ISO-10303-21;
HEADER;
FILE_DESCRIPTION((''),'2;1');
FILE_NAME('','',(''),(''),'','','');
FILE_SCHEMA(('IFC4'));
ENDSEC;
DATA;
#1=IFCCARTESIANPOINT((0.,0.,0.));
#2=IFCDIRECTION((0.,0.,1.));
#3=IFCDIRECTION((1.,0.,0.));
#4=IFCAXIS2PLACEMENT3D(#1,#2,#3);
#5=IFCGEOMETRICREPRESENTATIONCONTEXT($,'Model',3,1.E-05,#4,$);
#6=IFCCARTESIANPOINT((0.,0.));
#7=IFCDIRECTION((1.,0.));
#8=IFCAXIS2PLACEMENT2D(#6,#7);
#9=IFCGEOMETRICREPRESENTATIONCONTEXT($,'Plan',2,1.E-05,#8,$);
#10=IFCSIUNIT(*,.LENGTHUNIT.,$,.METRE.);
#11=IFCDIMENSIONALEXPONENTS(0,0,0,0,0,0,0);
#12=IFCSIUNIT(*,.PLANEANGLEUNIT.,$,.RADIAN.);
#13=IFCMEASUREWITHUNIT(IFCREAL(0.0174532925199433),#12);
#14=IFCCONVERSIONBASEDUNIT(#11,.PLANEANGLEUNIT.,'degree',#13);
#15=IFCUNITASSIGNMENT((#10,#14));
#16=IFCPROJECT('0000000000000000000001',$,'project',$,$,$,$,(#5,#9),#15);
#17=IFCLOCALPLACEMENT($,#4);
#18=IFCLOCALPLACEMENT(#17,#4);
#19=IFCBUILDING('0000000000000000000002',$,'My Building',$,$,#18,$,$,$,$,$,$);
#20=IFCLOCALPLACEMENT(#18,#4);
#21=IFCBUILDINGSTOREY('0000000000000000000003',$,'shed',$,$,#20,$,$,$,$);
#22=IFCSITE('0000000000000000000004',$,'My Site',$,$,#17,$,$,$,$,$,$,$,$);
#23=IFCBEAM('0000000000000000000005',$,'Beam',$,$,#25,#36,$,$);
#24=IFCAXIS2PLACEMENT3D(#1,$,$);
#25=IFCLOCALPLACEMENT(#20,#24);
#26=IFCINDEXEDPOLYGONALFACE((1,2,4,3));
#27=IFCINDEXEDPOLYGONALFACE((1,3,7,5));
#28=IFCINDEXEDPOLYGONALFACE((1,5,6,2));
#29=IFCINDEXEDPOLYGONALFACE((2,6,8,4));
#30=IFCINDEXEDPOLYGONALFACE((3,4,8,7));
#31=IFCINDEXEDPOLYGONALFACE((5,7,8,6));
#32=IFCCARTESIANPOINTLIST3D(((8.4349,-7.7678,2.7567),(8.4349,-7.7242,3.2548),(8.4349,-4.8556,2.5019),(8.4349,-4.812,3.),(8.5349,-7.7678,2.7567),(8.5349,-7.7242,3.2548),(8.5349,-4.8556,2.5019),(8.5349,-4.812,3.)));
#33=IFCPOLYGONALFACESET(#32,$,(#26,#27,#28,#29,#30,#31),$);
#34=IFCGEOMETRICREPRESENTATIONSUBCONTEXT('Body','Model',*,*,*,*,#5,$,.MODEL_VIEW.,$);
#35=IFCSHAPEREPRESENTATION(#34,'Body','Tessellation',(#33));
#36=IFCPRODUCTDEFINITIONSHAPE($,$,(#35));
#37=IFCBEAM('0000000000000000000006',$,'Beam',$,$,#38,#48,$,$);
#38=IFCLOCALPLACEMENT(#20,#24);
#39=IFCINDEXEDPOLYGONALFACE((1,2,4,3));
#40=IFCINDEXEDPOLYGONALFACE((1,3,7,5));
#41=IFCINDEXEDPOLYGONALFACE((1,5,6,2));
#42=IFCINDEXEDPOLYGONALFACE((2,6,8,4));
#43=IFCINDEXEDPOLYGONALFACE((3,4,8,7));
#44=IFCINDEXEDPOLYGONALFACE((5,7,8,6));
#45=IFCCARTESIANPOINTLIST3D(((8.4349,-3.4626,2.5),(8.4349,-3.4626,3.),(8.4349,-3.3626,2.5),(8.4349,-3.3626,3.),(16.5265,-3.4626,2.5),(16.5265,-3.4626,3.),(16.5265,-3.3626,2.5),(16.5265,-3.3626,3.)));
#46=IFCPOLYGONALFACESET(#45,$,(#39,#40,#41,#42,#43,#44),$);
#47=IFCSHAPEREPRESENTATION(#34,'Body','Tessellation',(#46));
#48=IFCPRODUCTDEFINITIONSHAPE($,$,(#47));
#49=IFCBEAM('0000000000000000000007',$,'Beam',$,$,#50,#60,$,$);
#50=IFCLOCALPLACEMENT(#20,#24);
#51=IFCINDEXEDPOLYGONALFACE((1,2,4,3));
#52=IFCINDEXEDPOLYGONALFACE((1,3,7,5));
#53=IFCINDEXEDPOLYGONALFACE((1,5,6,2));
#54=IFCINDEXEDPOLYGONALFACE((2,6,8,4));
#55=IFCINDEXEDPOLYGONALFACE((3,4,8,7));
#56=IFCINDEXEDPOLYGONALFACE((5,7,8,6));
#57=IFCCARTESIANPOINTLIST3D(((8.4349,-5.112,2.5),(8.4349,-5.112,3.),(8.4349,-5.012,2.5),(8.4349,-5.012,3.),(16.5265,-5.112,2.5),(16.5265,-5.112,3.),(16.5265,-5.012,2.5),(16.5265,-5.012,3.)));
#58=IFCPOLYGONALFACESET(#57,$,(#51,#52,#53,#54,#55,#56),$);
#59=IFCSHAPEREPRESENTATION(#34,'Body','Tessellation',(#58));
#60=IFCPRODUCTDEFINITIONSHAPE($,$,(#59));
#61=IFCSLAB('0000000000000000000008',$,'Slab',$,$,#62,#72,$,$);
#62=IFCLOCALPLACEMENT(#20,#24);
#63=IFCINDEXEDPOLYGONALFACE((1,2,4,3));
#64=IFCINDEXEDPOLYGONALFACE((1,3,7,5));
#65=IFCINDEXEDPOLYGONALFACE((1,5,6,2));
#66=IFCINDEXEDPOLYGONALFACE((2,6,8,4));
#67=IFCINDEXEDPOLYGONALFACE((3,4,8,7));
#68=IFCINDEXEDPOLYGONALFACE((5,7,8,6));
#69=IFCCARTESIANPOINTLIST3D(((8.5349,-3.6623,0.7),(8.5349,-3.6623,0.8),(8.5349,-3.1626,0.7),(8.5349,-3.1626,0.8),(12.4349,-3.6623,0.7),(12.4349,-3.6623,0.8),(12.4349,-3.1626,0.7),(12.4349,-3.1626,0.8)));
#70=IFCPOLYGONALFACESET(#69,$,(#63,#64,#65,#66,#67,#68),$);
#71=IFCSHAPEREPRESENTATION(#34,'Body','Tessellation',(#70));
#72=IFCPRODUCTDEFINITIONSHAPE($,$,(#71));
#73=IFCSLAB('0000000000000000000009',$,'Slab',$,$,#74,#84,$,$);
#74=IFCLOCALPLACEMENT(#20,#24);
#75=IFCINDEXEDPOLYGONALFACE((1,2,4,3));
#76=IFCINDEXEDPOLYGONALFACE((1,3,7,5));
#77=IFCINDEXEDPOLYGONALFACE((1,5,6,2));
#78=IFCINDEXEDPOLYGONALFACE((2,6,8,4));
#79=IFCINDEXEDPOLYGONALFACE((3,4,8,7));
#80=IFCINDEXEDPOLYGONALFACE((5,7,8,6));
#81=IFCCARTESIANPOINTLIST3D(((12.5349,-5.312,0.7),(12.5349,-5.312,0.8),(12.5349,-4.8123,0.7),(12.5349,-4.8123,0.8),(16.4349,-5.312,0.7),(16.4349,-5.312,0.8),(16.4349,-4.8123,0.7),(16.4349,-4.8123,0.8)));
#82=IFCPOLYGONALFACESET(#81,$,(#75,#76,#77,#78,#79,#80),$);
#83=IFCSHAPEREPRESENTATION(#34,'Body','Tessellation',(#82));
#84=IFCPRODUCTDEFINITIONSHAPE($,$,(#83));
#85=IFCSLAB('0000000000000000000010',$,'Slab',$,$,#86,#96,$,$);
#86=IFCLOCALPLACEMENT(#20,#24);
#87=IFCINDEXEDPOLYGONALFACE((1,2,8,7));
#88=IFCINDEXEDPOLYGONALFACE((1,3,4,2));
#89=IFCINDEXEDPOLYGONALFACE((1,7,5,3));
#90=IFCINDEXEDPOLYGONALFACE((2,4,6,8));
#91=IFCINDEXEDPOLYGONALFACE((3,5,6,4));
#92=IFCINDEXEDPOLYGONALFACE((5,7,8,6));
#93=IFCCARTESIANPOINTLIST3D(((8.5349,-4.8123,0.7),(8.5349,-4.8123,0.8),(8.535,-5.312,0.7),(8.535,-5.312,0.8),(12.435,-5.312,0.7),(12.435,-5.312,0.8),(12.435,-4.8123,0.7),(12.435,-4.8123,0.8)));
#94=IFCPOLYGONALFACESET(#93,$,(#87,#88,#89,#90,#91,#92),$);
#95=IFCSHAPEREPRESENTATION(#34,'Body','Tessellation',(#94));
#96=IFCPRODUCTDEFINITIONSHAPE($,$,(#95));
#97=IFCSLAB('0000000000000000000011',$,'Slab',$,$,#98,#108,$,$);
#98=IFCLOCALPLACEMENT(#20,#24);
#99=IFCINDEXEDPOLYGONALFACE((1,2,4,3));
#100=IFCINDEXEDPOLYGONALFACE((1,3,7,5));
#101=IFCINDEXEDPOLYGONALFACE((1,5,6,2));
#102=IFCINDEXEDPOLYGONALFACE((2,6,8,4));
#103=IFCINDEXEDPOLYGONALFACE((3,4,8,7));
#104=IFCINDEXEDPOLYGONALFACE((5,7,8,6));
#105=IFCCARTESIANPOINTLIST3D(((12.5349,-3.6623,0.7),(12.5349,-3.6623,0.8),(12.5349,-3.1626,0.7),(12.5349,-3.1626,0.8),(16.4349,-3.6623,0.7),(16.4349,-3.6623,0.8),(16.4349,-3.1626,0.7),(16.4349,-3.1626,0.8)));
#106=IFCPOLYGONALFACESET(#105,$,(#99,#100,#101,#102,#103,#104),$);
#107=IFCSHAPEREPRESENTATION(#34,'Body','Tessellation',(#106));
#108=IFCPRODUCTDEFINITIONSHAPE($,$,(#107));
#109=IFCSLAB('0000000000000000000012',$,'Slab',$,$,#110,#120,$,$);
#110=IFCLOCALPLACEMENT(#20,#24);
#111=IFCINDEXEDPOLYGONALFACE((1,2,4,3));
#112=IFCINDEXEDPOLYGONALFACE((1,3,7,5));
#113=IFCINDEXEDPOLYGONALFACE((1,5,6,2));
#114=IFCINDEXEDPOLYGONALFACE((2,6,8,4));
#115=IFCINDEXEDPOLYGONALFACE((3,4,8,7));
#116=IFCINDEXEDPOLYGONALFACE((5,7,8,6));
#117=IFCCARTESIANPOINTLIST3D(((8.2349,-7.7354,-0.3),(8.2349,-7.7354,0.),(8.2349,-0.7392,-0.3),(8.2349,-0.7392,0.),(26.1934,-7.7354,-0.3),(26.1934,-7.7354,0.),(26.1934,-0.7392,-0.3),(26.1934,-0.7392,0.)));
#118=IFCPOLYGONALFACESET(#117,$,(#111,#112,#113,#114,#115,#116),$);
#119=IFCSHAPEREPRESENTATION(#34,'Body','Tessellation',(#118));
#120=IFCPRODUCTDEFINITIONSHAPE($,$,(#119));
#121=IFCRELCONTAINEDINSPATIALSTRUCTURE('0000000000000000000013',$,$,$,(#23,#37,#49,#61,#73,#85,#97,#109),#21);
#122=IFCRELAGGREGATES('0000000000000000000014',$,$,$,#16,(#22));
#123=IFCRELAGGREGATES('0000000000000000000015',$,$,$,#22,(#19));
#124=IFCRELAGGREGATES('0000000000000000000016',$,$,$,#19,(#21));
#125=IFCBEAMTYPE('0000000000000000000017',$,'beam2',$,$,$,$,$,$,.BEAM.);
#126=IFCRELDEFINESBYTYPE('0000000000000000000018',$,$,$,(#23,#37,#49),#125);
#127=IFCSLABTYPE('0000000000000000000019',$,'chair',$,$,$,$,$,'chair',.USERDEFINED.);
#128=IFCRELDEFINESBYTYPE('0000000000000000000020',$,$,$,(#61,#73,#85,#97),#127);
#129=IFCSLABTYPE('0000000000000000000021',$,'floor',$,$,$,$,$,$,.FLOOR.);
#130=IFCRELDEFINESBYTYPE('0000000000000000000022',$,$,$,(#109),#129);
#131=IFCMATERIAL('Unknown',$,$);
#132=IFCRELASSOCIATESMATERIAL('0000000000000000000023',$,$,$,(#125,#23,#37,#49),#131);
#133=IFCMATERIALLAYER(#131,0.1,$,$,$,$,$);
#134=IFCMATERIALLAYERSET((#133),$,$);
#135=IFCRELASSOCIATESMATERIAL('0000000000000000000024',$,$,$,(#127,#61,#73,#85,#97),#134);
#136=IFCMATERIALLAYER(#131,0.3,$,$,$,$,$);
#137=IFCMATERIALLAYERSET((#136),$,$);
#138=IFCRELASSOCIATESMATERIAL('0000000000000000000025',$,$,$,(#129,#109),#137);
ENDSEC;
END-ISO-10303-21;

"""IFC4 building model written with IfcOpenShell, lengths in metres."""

from ifc_helpers import new_model, entity, si_unit, converted_unit, frame, origin_with_axes, origin_2d_with_axis, place, context, subcontext, project, spatial, indexed_curve, rectangle, outline, extrude, material, layer, layer_set, layer_usage, material_profile, profile_set, profile_usage, type_object, element, save


model = new_model("IFC4")

# Units and contexts
model_context = context("Model", 3, precision=1e-05, world=origin_with_axes())
plan_context = context("Plan", 2, precision=1e-05, world=origin_2d_with_axis())
body_context = subcontext(model_context, "Body", "Model", "MODEL_VIEW")
ifc_project = project(units=[si_unit("LENGTHUNIT", "METRE"), converted_unit("PLANEANGLEUNIT", "degree", entity("IfcReal", 0.0174532925199433), si_unit("PLANEANGLEUNIT", "RADIAN"), dimensions=[0, 0, 0, 0, 0, 0, 0])], contexts=[model_context, plan_context])

# Site, building, storey
site_placement = place(None, origin_with_axes())
site = spatial("IfcSite", under=ifc_project, at=site_placement, Name="My Site")
building_placement = place(site_placement, origin_with_axes())
building = spatial("IfcBuilding", under=site, at=building_placement, Name="My Building")
storey_placement = place(building_placement, origin_with_axes())
storey = spatial("IfcBuildingStorey", under=building, at=storey_placement, Name="shed")

# Shared definitions
ifc_material = material(Name="Unknown")

# Beams
ifc_material_profile_1 = material_profile(ifc_material, rectangle(XDim=0.1, YDim=0.5))
ifc_profile_set_1 = profile_set([ifc_material_profile_1])
beam_type = type_object("IfcBeamType", Name="beam2", PredefinedType="BEAM", material=ifc_profile_set_1)
ifc_profile_usage_1 = profile_usage(ifc_profile_set_1, cardinal=8)
beam_1_placement = place(storey_placement, frame((8.4849, -4.812, 3.0), z_axis=(0.0, -0.996195, 0.087156), x_axis=(1.0, 0.0, 0.0)))
element("IfcBeam", 1, at=beam_1_placement, inside=storey, type_object=beam_type, material=ifc_profile_usage_1, Name="Beam", context=body_context, shape_type="SweptSolid", body=[
    extrude(rectangle(XDim=0.1, YDim=0.5), frame((0.0, -0.25, 0.0), z_axis=(0.0, 0.0, 1.0), x_axis=(1.0, 0.0, 0.0)), (0.0, 0.0, 1.0), 2.9234),
])
ifc_profile_usage_2 = profile_usage(ifc_profile_set_1, cardinal=8)
beam_2_placement = place(storey_placement, frame((8.4349, -3.4126, 3.0), z_axis=(1.0, -0.000001, 0.000001), x_axis=(0.000001, 1.0, 0.0)))
element("IfcBeam", 2, at=beam_2_placement, inside=storey, type_object=beam_type, material=ifc_profile_usage_2, Name="Beam", context=body_context, shape_type="SweptSolid", body=[
    extrude(rectangle(XDim=0.1, YDim=0.5), frame((0.0, -0.25, 0.0), z_axis=(0.0, 0.0, 1.0), x_axis=(1.0, 0.0, 0.0)), (0.0, 0.0, 1.0), 8.0916),
])
ifc_profile_usage_3 = profile_usage(ifc_profile_set_1, cardinal=8)
beam_3_placement = place(storey_placement, frame((8.4349, -5.062, 3.0), z_axis=(1.0, -0.000001, 0.000001), x_axis=(0.000001, 1.0, 0.0)))
element("IfcBeam", 3, at=beam_3_placement, inside=storey, type_object=beam_type, material=ifc_profile_usage_3, Name="Beam", context=body_context, shape_type="SweptSolid", body=[
    extrude(rectangle(XDim=0.1, YDim=0.5), frame((0.0, -0.25, 0.0), z_axis=(0.0, 0.0, 1.0), x_axis=(1.0, 0.0, 0.0)), (0.0, 0.0, 1.0), 8.0916),
])

# Slabs
ifc_layer_1 = layer(ifc_material, 0.1)
ifc_layer_set_1 = layer_set([ifc_layer_1])
ifc_layer_usage_1 = layer_usage(ifc_layer_set_1, "AXIS3", "POSITIVE", -0.1)
slab_type_1 = type_object("IfcSlabType", Name="chair", ElementType="chair", PredefinedType="USERDEFINED", material=ifc_layer_set_1)
slab_1_placement = place(storey_placement, frame((8.5349, -3.6623, 0.8), z_axis=(0.0, 0.0, 1.0), x_axis=(1.0, 0.0, 0.0)))
element("IfcSlab", 4, at=slab_1_placement, inside=storey, type_object=slab_type_1, material=ifc_layer_usage_1, Name="Slab", context=body_context, shape_type="SweptSolid", body=[
    extrude(outline(indexed_curve([(0.0, 0.0), (3.9, 0.0), (3.9, 0.4997), (0.0, 0.4997), (0.0, 0.0)])), frame((0.0, 0.0, -0.1), z_axis=(0.0, 0.0, 1.0), x_axis=(1.0, 0.0, 0.0)), (0.0, 0.0, 1.0), 0.1),
])
ifc_layer_usage_2 = layer_usage(ifc_layer_set_1, "AXIS3", "POSITIVE", -0.1)
slab_2_placement = place(storey_placement, frame((12.5349, -5.312, 0.8), z_axis=(0.0, 0.0, 1.0), x_axis=(1.0, 0.0, 0.0)))
element("IfcSlab", 5, at=slab_2_placement, inside=storey, type_object=slab_type_1, material=ifc_layer_usage_2, Name="Slab", context=body_context, shape_type="SweptSolid", body=[
    extrude(outline(indexed_curve([(0.0, 0.0), (3.9, 0.0), (3.9, 0.4997), (0.0, 0.4997), (0.0, 0.0)])), frame((0.0, 0.0, -0.1), z_axis=(0.0, 0.0, 1.0), x_axis=(1.0, 0.0, 0.0)), (0.0, 0.0, 1.0), 0.1),
])
ifc_layer_usage_3 = layer_usage(ifc_layer_set_1, "AXIS3", "POSITIVE", -0.1)
slab_3_placement = place(storey_placement, frame((8.535, -5.312, 0.8), z_axis=(0.0, 0.0, 1.0), x_axis=(1.0, 0.0, 0.0)))
element("IfcSlab", 6, at=slab_3_placement, inside=storey, type_object=slab_type_1, material=ifc_layer_usage_3, Name="Slab", context=body_context, shape_type="SweptSolid", body=[
    extrude(outline(indexed_curve([(0.0, 0.0), (3.9, 0.0), (3.9, 0.4997), (0.0, 0.4997), (0.0, 0.0)])), frame((0.0, 0.0, -0.1), z_axis=(0.0, 0.0, 1.0), x_axis=(1.0, 0.0, 0.0)), (0.0, 0.0, 1.0), 0.1),
])
ifc_layer_usage_4 = layer_usage(ifc_layer_set_1, "AXIS3", "POSITIVE", -0.1)
slab_4_placement = place(storey_placement, frame((12.5349, -3.6623, 0.8), z_axis=(0.0, 0.0, 1.0), x_axis=(1.0, 0.0, 0.0)))
element("IfcSlab", 7, at=slab_4_placement, inside=storey, type_object=slab_type_1, material=ifc_layer_usage_4, Name="Slab", context=body_context, shape_type="SweptSolid", body=[
    extrude(outline(indexed_curve([(0.0, 0.0), (3.9, 0.0), (3.9, 0.4997), (0.0, 0.4997), (0.0, 0.0)])), frame((0.0, 0.0, -0.1), z_axis=(0.0, 0.0, 1.0), x_axis=(1.0, 0.0, 0.0)), (0.0, 0.0, 1.0), 0.1),
])
ifc_layer_2 = layer(ifc_material, 0.3)
ifc_layer_set_2 = layer_set([ifc_layer_2])
ifc_layer_usage_5 = layer_usage(ifc_layer_set_2, "AXIS3", "POSITIVE", -0.3)
slab_type_2 = type_object("IfcSlabType", Name="floor", PredefinedType="FLOOR", material=ifc_layer_set_2)
slab_5_placement = place(storey_placement, frame((8.2349, -0.7392, 0.0), z_axis=(0.0, 0.0, 1.0), x_axis=(1.0, 0.0, 0.0)))
element("IfcSlab", 8, at=slab_5_placement, inside=storey, type_object=slab_type_2, material=ifc_layer_usage_5, Name="Slab", context=body_context, shape_type="SweptSolid", body=[
    extrude(outline(indexed_curve([(0.0, 0.0), (17.9585, 0.0), (17.9585, -6.9962), (0.0, -6.9962), (0.0, 0.0)])), frame((0.0, 0.0, -0.3), z_axis=(0.0, 0.0, 1.0), x_axis=(1.0, 0.0, 0.0)), (0.0, 0.0, 1.0), 0.3),
])

save(model, "model.ifc")
